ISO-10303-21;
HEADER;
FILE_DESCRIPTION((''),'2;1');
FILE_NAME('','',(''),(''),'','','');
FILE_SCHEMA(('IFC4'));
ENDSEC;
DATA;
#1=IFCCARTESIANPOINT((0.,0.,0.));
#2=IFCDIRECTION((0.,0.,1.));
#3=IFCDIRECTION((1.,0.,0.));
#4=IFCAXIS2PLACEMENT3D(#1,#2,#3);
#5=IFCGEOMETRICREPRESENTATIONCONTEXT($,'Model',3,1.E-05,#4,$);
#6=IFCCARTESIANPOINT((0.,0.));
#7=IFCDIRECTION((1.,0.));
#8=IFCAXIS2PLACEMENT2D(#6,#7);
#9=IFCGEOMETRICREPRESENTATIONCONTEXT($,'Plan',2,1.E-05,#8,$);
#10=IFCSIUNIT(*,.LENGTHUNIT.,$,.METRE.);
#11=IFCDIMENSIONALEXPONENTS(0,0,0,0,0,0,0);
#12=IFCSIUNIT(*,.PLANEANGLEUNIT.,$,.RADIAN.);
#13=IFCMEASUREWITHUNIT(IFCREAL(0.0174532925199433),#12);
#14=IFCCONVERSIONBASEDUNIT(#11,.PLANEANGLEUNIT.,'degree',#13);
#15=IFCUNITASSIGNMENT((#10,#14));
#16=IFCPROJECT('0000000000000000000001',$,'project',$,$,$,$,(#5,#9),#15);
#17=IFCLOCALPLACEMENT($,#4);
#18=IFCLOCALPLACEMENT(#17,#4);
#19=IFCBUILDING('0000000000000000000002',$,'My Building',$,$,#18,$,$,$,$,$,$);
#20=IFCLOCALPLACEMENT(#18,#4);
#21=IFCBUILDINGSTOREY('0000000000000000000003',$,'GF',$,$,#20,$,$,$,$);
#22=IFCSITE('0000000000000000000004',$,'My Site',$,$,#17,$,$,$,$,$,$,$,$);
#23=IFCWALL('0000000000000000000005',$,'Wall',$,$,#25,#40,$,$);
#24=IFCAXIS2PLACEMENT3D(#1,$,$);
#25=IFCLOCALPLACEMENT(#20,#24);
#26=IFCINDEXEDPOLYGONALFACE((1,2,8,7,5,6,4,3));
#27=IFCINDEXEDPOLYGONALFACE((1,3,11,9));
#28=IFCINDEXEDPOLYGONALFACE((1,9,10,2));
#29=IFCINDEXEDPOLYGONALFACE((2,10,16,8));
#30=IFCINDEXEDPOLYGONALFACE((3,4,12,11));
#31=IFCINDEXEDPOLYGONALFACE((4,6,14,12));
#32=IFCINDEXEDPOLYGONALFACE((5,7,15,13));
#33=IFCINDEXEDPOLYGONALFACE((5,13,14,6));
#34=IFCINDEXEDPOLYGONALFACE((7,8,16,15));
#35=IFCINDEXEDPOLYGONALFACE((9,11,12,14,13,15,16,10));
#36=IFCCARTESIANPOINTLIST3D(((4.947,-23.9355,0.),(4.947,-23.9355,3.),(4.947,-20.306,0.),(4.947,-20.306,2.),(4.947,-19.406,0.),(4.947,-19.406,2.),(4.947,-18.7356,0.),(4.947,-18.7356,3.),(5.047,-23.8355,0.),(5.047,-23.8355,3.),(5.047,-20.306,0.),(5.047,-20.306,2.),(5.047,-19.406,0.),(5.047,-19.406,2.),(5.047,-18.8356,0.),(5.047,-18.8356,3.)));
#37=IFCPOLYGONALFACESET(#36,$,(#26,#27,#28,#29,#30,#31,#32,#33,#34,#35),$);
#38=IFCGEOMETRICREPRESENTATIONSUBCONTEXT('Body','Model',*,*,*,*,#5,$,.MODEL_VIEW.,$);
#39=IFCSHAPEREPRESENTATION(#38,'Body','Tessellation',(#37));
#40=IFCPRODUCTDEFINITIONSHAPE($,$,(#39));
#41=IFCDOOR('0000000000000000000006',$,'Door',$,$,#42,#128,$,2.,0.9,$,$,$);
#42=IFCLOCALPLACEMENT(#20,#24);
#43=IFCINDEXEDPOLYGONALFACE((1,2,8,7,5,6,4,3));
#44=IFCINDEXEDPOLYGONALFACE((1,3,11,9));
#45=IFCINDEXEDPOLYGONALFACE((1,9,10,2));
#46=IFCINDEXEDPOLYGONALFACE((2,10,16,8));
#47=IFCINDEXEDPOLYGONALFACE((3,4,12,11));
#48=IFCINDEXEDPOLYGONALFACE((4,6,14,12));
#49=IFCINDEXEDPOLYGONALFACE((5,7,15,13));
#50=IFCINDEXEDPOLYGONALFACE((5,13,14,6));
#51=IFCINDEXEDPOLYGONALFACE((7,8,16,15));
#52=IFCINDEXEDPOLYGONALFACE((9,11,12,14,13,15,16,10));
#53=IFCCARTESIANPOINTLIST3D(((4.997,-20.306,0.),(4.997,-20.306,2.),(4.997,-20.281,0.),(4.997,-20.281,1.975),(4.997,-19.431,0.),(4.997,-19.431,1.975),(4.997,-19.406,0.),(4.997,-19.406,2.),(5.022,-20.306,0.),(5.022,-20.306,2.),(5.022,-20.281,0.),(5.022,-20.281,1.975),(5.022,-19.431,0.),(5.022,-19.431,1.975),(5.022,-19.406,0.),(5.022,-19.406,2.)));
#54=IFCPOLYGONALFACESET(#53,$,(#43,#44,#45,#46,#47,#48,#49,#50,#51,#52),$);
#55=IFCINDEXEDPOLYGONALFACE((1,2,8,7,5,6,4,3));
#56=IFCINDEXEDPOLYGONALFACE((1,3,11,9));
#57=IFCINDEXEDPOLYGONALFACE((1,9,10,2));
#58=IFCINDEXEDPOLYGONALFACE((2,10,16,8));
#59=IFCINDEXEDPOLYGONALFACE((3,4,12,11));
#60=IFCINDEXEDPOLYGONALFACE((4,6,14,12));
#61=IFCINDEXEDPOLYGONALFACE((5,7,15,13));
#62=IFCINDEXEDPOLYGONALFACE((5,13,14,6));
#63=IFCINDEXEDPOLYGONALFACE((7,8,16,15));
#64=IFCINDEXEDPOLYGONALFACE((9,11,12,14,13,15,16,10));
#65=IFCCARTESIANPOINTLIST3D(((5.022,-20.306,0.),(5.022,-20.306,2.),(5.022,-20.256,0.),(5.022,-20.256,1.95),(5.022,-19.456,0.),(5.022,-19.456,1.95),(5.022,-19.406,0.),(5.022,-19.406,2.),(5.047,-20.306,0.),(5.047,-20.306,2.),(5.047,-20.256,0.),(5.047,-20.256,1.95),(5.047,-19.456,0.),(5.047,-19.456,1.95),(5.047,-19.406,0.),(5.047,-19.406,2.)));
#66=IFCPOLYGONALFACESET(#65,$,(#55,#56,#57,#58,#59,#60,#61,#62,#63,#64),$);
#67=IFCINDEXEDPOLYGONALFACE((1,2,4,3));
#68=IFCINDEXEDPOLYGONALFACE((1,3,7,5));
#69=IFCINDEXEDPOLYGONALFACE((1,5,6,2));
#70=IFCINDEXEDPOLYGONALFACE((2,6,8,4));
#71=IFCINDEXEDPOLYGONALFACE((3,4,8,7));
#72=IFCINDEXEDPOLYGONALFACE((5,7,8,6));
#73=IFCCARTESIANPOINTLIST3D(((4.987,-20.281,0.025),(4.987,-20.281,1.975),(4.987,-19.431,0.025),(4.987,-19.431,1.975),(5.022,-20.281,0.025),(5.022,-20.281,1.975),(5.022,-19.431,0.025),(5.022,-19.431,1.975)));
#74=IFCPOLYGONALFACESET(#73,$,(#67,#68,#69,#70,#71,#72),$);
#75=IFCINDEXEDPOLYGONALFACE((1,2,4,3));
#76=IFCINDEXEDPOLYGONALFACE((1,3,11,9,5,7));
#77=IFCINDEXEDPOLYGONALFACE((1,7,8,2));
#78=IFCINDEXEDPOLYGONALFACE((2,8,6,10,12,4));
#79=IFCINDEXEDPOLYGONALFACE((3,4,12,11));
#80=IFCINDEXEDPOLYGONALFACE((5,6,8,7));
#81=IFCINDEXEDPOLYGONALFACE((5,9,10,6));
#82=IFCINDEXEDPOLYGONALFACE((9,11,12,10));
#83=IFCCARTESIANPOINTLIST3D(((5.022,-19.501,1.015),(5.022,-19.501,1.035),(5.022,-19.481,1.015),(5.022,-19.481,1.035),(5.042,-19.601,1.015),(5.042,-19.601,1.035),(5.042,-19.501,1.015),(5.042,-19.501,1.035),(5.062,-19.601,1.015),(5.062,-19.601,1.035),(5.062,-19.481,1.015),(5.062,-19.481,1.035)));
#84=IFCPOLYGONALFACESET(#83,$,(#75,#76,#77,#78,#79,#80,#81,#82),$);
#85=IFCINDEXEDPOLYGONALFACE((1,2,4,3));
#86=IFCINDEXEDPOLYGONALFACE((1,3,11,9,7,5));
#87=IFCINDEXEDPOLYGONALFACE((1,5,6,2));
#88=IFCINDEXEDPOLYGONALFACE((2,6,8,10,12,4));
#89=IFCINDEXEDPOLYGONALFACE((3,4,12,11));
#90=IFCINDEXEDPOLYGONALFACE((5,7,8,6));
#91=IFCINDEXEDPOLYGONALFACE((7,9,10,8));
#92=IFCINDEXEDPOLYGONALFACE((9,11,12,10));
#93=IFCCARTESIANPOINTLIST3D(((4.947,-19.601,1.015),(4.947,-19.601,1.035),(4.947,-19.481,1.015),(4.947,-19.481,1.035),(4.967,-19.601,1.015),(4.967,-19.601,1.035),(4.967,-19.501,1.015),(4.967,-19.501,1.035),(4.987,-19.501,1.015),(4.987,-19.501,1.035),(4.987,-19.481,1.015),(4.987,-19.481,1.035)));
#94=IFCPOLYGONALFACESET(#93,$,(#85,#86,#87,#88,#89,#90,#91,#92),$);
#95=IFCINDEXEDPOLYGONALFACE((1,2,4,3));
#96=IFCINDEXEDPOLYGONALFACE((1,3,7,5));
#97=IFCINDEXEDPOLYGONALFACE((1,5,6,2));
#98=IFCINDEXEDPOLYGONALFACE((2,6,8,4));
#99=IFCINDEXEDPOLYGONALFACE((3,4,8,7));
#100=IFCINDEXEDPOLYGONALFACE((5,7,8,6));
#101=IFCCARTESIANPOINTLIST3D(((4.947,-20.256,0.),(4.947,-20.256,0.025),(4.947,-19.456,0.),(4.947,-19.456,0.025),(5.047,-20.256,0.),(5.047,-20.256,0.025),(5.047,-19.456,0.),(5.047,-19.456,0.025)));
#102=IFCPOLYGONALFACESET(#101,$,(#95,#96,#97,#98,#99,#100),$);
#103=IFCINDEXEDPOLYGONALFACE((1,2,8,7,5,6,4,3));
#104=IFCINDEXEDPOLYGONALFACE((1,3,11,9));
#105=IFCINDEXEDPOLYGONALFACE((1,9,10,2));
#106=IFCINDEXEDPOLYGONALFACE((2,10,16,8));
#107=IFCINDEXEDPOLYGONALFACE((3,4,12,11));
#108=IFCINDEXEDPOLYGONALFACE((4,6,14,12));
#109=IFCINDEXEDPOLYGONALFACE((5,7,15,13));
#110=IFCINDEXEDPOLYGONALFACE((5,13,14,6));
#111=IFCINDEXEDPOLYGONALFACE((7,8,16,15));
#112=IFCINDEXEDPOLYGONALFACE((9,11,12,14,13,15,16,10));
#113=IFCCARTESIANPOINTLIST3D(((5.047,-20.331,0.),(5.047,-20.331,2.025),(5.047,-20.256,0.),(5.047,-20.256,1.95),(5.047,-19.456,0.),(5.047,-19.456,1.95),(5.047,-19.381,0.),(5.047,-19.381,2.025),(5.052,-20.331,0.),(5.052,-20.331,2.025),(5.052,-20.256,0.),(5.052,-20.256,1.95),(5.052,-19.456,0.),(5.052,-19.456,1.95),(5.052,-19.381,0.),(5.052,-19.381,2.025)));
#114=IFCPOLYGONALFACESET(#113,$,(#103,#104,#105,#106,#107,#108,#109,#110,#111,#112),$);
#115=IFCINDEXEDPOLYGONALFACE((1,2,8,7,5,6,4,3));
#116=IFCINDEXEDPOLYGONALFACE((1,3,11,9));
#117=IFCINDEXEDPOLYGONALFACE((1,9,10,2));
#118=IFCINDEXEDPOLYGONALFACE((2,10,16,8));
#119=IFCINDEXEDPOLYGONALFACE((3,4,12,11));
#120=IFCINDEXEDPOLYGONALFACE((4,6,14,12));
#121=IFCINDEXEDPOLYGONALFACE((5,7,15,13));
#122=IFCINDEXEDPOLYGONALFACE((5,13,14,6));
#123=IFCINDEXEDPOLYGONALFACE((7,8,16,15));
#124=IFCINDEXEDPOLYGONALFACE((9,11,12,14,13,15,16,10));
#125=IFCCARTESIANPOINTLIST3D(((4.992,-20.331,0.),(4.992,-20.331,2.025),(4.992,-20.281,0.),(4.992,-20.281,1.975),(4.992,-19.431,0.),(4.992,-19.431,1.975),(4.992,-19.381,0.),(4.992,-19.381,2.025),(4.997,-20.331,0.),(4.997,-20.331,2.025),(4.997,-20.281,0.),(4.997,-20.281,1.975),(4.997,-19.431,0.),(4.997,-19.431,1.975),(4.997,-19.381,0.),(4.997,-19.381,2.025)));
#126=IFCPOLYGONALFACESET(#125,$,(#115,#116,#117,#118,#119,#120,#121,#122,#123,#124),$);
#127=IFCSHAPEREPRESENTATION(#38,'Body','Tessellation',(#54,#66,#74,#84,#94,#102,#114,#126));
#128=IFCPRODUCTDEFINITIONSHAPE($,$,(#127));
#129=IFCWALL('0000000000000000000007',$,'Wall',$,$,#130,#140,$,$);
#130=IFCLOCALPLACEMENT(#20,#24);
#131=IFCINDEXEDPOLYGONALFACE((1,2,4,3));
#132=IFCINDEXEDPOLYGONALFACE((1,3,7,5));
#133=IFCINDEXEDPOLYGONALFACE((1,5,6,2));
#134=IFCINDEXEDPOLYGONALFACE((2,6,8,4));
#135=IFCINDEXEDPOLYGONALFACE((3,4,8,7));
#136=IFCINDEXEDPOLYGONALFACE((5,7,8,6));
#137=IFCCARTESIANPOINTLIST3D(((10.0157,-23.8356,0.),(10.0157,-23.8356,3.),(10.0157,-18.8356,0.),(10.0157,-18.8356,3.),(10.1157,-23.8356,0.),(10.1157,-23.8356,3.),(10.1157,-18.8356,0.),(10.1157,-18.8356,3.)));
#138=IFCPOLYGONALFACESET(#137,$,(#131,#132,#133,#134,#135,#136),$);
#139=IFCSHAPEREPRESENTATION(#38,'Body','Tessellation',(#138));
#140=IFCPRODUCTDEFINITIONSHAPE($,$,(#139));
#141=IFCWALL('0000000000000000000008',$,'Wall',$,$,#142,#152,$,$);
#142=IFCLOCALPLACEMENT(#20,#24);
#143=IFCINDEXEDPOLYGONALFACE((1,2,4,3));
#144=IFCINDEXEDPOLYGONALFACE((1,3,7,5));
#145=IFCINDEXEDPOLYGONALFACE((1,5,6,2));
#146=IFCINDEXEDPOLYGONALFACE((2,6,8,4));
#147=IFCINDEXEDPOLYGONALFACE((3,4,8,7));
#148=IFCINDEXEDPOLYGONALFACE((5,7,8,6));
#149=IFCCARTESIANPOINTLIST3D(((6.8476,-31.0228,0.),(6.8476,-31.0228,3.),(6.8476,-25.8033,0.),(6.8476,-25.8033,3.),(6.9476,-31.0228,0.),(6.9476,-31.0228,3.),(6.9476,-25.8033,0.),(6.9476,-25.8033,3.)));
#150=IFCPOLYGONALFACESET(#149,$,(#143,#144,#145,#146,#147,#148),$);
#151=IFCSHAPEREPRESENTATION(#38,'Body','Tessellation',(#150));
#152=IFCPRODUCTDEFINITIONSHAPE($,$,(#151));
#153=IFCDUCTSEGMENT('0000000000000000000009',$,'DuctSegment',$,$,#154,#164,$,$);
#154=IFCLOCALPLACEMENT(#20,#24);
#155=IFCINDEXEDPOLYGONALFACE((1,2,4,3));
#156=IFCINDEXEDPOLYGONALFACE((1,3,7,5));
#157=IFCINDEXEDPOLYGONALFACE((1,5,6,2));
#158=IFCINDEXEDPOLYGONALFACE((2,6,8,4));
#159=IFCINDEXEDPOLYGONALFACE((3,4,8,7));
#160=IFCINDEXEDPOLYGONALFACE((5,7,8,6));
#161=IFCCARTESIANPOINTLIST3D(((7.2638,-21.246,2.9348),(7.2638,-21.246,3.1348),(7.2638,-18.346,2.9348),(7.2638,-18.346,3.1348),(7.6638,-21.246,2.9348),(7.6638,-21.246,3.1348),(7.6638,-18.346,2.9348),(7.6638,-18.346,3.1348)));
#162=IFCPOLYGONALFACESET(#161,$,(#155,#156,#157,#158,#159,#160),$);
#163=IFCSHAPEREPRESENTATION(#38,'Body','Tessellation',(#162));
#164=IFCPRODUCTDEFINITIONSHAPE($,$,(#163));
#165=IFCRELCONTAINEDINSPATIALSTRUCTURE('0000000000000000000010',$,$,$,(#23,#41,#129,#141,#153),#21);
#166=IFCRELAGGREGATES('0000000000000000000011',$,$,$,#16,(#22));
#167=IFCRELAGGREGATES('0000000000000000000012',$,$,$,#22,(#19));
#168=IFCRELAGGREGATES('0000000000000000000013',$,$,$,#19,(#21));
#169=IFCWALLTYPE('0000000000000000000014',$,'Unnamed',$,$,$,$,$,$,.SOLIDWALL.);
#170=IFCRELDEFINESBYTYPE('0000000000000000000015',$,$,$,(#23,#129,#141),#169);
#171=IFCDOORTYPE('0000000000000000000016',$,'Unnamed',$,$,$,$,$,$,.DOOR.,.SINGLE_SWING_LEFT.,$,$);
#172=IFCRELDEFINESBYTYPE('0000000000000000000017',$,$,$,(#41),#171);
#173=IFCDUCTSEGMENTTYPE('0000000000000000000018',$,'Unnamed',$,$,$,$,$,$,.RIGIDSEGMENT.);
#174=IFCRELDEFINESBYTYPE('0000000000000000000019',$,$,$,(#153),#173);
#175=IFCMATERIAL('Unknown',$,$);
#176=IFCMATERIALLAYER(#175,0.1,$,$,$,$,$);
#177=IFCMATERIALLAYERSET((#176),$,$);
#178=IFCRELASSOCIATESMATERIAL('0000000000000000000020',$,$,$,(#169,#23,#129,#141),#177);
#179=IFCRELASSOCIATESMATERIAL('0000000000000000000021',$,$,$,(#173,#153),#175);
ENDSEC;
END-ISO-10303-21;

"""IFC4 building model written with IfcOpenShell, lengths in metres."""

from ifc_helpers import new_model, entity, si_unit, converted_unit, frame, origin_with_axes, origin_2d_with_axis, place, context, subcontext, project, spatial, line, indexed_curve, rectangle, outline, extrude, shape, source, transform, mapped, material, layer, layer_set, layer_usage, material_profile, profile_set, profile_usage, type_object, type_shapes, element, fill, save


model = new_model("IFC4")

# Units and contexts
model_context = context("Model", 3, precision=1e-05, world=origin_with_axes())
plan_context = context("Plan", 2, precision=1e-05, world=origin_2d_with_axis())
body_context_1 = subcontext(model_context, "Body", "Model", "MODEL_VIEW")
body_context_2 = subcontext(plan_context, "Body", "Plan", "PLAN_VIEW")
ifc_project = project(units=[si_unit("LENGTHUNIT", "METRE"), converted_unit("PLANEANGLEUNIT", "degree", entity("IfcReal", 0.0174532925199433), si_unit("PLANEANGLEUNIT", "RADIAN"), dimensions=[0, 0, 0, 0, 0, 0, 0])], contexts=[model_context, plan_context])

# Site, building, storey
site_placement = place(None, origin_with_axes())
site = spatial("IfcSite", under=ifc_project, at=site_placement, Name="My Site")
building_placement = place(site_placement, origin_with_axes())
building = spatial("IfcBuilding", under=site, at=building_placement, Name="My Building")
storey_placement = place(building_placement, origin_with_axes())
storey = spatial("IfcBuildingStorey", under=building, at=storey_placement, Name="GF")

# Shared definitions
ifc_material = material(Name="Unknown")
ifc_layer = layer(ifc_material, 0.1)
ifc_layer_set = layer_set([ifc_layer])
wall_type = type_object("IfcWallType", Name="Unnamed", PredefinedType="SOLIDWALL", material=ifc_layer_set)

# Shared definitions
shared_shape_1 = source(origin_with_axes(), body_context_1, "Body", "SweptSolid", [
    extrude(outline(indexed_curve([(0.0, 0.0), (0.9, 0.0), (0.9, 2.0), (0.0, 2.0)], segments=[line(1, 2, 3, 4, 1)])), frame((0.0, -0.6, 0.0), z_axis=(0.0, -1.0, 0.0), x_axis=(1.0, 0.0, 0.0)), (0.0, 0.0, -1.0), 1.2),
])
door_type = type_object("IfcDoorType", Name="Unnamed", OperationType="SINGLE_SWING_LEFT", PredefinedType="DOOR")
shared_shape_2 = source(origin_with_axes(), body_context_1, "Body", "SweptSolid", [
    extrude(outline(indexed_curve([(0.0, 0.0), (0.0, 2.0), (0.9, 2.0), (0.9, 0.0), (0.875, 0.0), (0.875, 1.975), (0.025, 1.975), (0.025, 0.0)], segments=[line(1, 2, 3, 4, 5, 6, 7, 8, 1)])), frame((0.0, 0.025, 0.0), z_axis=(0.0, -1.0, 0.0), x_axis=(1.0, 0.0, 0.0)), (0.0, 0.0, -1.0), 0.025),
    extrude(outline(indexed_curve([(0.0, 0.0), (0.0, 2.0), (0.9, 2.0), (0.9, 0.0), (0.85, 0.0), (0.85, 1.95), (0.05, 1.95), (0.05, 0.0)], segments=[line(1, 2, 3, 4, 5, 6, 7, 8, 1)])), frame((0.0, 0.0, 0.0), z_axis=(0.0, -1.0, 0.0), x_axis=(1.0, 0.0, 0.0)), (0.0, 0.0, -1.0), 0.025),
    extrude(outline(indexed_curve([(0.0, 0.0), (0.85, 0.0), (0.85, 0.035), (0.0, 0.035)], segments=[line(1, 2, 3, 4, 1)])), frame((0.025, 0.025, 0.025), z_axis=(0.0, 0.0, 1.0), x_axis=(1.0, 0.0, 0.0)), (0.0, 0.0, 1.0), 1.95),
    extrude(outline(indexed_curve([(0.0, 0.0), (0.0, -0.04), (-0.12, -0.04), (-0.12, -0.02), (-0.02, -0.02), (-0.02, 0.0)], segments=[line(1, 2, 3, 4, 5, 6, 1)])), frame((0.825, 0.025, 1.015), z_axis=(0.0, 0.0, 1.0), x_axis=(1.0, 0.0, 0.0)), (0.0, 0.0, 1.0), 0.02),
    extrude(outline(indexed_curve([(0.0, 0.0), (0.0, 0.04), (-0.12, 0.04), (-0.12, 0.02), (-0.02, 0.02), (-0.02, 0.0)], segments=[line(1, 2, 3, 4, 5, 6, 1)])), frame((0.825, 0.06, 1.015), z_axis=(0.0, 0.0, 1.0), x_axis=(1.0, 0.0, 0.0)), (0.0, 0.0, 1.0), 0.02),
    extrude(outline(indexed_curve([(0.0, 0.0), (0.8, 0.0), (0.8, 0.1), (0.0, 0.1)], segments=[line(1, 2, 3, 4, 1)])), frame((0.05, 0.0, 0.0), z_axis=(0.0, 0.0, 1.0), x_axis=(1.0, 0.0, 0.0)), (0.0, 0.0, 1.0), 0.025),
    extrude(outline(indexed_curve([(0.0, 0.0), (0.0, 2.025), (0.95, 2.025), (0.95, 0.0), (0.875, 0.0), (0.875, 1.95), (0.075, 1.95), (0.075, 0.0)], segments=[line(1, 2, 3, 4, 5, 6, 7, 8, 1)])), frame((-0.025, -0.005, 0.0), z_axis=(0.0, -1.0, 0.0), x_axis=(1.0, 0.0, 0.0)), (0.0, 0.0, -1.0), 0.005),
    extrude(outline(indexed_curve([(0.0, 0.0), (0.0, 2.025), (0.95, 2.025), (0.95, 0.0), (0.9, 0.0), (0.9, 1.975), (0.05, 1.975), (0.05, 0.0)], segments=[line(1, 2, 3, 4, 5, 6, 7, 8, 1)])), frame((-0.025, 0.05, 0.0), z_axis=(0.0, -1.0, 0.0), x_axis=(1.0, 0.0, 0.0)), (0.0, 0.0, -1.0), 0.005),
])
shared_shape_3 = source(origin_with_axes(), body_context_2, "Body", "Curve2D", [
    entity("IfcIndexedPolyCurve", entity("IfcCartesianPointList2D", [[0.0, 0.0], [0.0, 0.05], [0.025, 0.05], [0.025, 0.025], [0.05, 0.025], [0.05, 0.0]]), [entity("IfcLineIndex", [1, 2, 3, 4, 5, 6, 1])]),
    entity("IfcIndexedPolyCurve", entity("IfcCartesianPointList2D", [[0.9, 0.0], [0.9, 0.05], [0.875, 0.05], [0.875, 0.025], [0.85, 0.025], [0.85, 0.0]]), [entity("IfcLineIndex", [1, 2, 3, 4, 5, 6, 1])]),
    entity("IfcTrimmedCurve", entity("IfcEllipse", entity("IfcAxis2Placement2D", entity("IfcCartesianPoint", [0.06, 0.05]), entity("IfcDirection", [1.0, 0.0])), 0.815, 0.85), [entity("IfcCartesianPoint", [0.875, 0.05])], [entity("IfcCartesianPoint", [0.06, 0.9])], True, "CARTESIAN"),
    entity("IfcIndexedPolyCurve", entity("IfcCartesianPointList2D", [[0.025, 0.05], [0.06, 0.05], [0.06, 0.9], [0.025, 0.9]]), [entity("IfcLineIndex", [1, 2, 3, 4, 1])]),
])
type_shapes(door_type, [shared_shape_2, shared_shape_3])

# Wall, opening, door
ifc_layer_usage_1 = layer_usage(ifc_layer_set, "AXIS2", "POSITIVE", 0.0)
wall_1_placement = place(storey_placement, frame((5.047, -23.8355, 0.0), z_axis=(0.0, 0.0, 1.0), x_axis=(0.0, 1.0, 0.0)))
wall_1 = element("IfcWall", 1, at=wall_1_placement, inside=storey, type_object=wall_type, material=ifc_layer_usage_1, Name="Wall", context=body_context_1, shape_type="SweptSolid", body=[
    extrude(outline(indexed_curve([(0.0, 0.0), (-0.1, 0.1), (5.1, 0.1), (5.0, 0.0)], segments=[line(1, 2, 3, 4, 1)])), origin_with_axes(), (0.0, 0.0, 1.0), 3.0),
])
opening_1_placement = place(wall_1_placement, frame((3.5295, 0.0, 0.0), z_axis=(0.0, 0.0, 1.0), x_axis=(1.0, 0.0, 0.0)))
opening_1 = element("IfcOpeningElement", 2, at=opening_1_placement, cuts=wall_1, PredefinedType="OPENING", context=body_context_1, shape_type="MappedRepresentation", body=[
    mapped(shared_shape_1, transform((0.0, 0.0, 0.0), x_axis=(1.0, 0.0, 0.0), y_axis=(0.0, 1.0, 0.0), z_axis=(0.0, 0.0, 1.0), scale=1.0)),
])
door_1_placement = place(opening_1_placement, frame((0.0, 0.0, 0.0), z_axis=(0.0, 0.0, 1.0), x_axis=(1.0, 0.0, 0.0)))
door_1 = element("IfcDoor", 3, at=door_1_placement, inside=storey, type_object=door_type, Name="Door", OverallHeight=2.0, OverallWidth=0.9, shapes=[
    shape(body_context_1, "Body", "MappedRepresentation", [mapped(shared_shape_2, transform((0.0, 0.0, 0.0), x_axis=(1.0, 0.0, 0.0), y_axis=(0.0, 1.0, 0.0), z_axis=(0.0, 0.0, 1.0), scale=1.0))]),
    shape(body_context_2, "Body", "MappedRepresentation", [mapped(shared_shape_3, transform((0.0, 0.0, 0.0), x_axis=(1.0, 0.0, 0.0), y_axis=(0.0, 1.0, 0.0), z_axis=(0.0, 0.0, 1.0), scale=1.0))]),
])
fill(opening_1, door_1)

# Walls
ifc_layer_usage_2 = layer_usage(ifc_layer_set, "AXIS2", "POSITIVE", 0.0)
wall_2_placement = place(storey_placement, frame((10.0157, -18.8356, 0.0), z_axis=(0.0, 0.0, 1.0), x_axis=(0.0, -1.0, 0.0)))
element("IfcWall", 4, at=wall_2_placement, inside=storey, type_object=wall_type, material=ifc_layer_usage_2, Name="Wall", context=body_context_1, shape_type="SweptSolid", body=[
    extrude(outline(indexed_curve([(0.0, 0.0), (0.0, 0.1), (5.0, 0.1), (5.0, 0.0)], segments=[line(1, 2, 3, 4, 1)])), origin_with_axes(), (0.0, 0.0, 1.0), 3.0),
])
ifc_layer_usage_3 = layer_usage(ifc_layer_set, "AXIS2", "POSITIVE", 0.0)
wall_3_placement = place(storey_placement, frame((6.8476, -25.8033, 0.0), z_axis=(0.0, 0.0, 1.0), x_axis=(0.0, -1.0, 0.0)))
element("IfcWall", 5, at=wall_3_placement, inside=storey, type_object=wall_type, material=ifc_layer_usage_3, Name="Wall", context=body_context_1, shape_type="SweptSolid", body=[
    extrude(outline(indexed_curve([(0.0, 0.0), (0.0, 0.1), (5.2195, 0.1), (5.2195, 0.0)], segments=[line(1, 2, 3, 4, 1)])), origin_with_axes(), (0.0, 0.0, 1.0), 3.0),
])

# Duct segment
ifc_material_profile_1 = material_profile(ifc_material, rectangle(XDim=0.4, YDim=0.2))
ifc_profile_set_1 = profile_set([ifc_material_profile_1])
ifc_profile_usage_1 = profile_usage(ifc_profile_set_1, cardinal=5)
duct_segment_type = type_object("IfcDuctSegmentType", Name="Unnamed", PredefinedType="RIGIDSEGMENT", material=ifc_profile_set_1)
duct_segment_placement = place(storey_placement, frame((7.4638, -18.346, 3.0348), z_axis=(0.0, -1.0, 0.000001), x_axis=(1.0, 0.0, 0.0)))
element("IfcDuctSegment", 6, at=duct_segment_placement, inside=storey, type_object=duct_segment_type, material=ifc_profile_usage_1, Name="DuctSegment", context=body_context_1, shape_type="SweptSolid", body=[
    extrude(rectangle(XDim=0.4, YDim=0.2), origin_with_axes(), (0.0, 0.0, 1.0), 2.9),
])

save(model, "model.ifc")
